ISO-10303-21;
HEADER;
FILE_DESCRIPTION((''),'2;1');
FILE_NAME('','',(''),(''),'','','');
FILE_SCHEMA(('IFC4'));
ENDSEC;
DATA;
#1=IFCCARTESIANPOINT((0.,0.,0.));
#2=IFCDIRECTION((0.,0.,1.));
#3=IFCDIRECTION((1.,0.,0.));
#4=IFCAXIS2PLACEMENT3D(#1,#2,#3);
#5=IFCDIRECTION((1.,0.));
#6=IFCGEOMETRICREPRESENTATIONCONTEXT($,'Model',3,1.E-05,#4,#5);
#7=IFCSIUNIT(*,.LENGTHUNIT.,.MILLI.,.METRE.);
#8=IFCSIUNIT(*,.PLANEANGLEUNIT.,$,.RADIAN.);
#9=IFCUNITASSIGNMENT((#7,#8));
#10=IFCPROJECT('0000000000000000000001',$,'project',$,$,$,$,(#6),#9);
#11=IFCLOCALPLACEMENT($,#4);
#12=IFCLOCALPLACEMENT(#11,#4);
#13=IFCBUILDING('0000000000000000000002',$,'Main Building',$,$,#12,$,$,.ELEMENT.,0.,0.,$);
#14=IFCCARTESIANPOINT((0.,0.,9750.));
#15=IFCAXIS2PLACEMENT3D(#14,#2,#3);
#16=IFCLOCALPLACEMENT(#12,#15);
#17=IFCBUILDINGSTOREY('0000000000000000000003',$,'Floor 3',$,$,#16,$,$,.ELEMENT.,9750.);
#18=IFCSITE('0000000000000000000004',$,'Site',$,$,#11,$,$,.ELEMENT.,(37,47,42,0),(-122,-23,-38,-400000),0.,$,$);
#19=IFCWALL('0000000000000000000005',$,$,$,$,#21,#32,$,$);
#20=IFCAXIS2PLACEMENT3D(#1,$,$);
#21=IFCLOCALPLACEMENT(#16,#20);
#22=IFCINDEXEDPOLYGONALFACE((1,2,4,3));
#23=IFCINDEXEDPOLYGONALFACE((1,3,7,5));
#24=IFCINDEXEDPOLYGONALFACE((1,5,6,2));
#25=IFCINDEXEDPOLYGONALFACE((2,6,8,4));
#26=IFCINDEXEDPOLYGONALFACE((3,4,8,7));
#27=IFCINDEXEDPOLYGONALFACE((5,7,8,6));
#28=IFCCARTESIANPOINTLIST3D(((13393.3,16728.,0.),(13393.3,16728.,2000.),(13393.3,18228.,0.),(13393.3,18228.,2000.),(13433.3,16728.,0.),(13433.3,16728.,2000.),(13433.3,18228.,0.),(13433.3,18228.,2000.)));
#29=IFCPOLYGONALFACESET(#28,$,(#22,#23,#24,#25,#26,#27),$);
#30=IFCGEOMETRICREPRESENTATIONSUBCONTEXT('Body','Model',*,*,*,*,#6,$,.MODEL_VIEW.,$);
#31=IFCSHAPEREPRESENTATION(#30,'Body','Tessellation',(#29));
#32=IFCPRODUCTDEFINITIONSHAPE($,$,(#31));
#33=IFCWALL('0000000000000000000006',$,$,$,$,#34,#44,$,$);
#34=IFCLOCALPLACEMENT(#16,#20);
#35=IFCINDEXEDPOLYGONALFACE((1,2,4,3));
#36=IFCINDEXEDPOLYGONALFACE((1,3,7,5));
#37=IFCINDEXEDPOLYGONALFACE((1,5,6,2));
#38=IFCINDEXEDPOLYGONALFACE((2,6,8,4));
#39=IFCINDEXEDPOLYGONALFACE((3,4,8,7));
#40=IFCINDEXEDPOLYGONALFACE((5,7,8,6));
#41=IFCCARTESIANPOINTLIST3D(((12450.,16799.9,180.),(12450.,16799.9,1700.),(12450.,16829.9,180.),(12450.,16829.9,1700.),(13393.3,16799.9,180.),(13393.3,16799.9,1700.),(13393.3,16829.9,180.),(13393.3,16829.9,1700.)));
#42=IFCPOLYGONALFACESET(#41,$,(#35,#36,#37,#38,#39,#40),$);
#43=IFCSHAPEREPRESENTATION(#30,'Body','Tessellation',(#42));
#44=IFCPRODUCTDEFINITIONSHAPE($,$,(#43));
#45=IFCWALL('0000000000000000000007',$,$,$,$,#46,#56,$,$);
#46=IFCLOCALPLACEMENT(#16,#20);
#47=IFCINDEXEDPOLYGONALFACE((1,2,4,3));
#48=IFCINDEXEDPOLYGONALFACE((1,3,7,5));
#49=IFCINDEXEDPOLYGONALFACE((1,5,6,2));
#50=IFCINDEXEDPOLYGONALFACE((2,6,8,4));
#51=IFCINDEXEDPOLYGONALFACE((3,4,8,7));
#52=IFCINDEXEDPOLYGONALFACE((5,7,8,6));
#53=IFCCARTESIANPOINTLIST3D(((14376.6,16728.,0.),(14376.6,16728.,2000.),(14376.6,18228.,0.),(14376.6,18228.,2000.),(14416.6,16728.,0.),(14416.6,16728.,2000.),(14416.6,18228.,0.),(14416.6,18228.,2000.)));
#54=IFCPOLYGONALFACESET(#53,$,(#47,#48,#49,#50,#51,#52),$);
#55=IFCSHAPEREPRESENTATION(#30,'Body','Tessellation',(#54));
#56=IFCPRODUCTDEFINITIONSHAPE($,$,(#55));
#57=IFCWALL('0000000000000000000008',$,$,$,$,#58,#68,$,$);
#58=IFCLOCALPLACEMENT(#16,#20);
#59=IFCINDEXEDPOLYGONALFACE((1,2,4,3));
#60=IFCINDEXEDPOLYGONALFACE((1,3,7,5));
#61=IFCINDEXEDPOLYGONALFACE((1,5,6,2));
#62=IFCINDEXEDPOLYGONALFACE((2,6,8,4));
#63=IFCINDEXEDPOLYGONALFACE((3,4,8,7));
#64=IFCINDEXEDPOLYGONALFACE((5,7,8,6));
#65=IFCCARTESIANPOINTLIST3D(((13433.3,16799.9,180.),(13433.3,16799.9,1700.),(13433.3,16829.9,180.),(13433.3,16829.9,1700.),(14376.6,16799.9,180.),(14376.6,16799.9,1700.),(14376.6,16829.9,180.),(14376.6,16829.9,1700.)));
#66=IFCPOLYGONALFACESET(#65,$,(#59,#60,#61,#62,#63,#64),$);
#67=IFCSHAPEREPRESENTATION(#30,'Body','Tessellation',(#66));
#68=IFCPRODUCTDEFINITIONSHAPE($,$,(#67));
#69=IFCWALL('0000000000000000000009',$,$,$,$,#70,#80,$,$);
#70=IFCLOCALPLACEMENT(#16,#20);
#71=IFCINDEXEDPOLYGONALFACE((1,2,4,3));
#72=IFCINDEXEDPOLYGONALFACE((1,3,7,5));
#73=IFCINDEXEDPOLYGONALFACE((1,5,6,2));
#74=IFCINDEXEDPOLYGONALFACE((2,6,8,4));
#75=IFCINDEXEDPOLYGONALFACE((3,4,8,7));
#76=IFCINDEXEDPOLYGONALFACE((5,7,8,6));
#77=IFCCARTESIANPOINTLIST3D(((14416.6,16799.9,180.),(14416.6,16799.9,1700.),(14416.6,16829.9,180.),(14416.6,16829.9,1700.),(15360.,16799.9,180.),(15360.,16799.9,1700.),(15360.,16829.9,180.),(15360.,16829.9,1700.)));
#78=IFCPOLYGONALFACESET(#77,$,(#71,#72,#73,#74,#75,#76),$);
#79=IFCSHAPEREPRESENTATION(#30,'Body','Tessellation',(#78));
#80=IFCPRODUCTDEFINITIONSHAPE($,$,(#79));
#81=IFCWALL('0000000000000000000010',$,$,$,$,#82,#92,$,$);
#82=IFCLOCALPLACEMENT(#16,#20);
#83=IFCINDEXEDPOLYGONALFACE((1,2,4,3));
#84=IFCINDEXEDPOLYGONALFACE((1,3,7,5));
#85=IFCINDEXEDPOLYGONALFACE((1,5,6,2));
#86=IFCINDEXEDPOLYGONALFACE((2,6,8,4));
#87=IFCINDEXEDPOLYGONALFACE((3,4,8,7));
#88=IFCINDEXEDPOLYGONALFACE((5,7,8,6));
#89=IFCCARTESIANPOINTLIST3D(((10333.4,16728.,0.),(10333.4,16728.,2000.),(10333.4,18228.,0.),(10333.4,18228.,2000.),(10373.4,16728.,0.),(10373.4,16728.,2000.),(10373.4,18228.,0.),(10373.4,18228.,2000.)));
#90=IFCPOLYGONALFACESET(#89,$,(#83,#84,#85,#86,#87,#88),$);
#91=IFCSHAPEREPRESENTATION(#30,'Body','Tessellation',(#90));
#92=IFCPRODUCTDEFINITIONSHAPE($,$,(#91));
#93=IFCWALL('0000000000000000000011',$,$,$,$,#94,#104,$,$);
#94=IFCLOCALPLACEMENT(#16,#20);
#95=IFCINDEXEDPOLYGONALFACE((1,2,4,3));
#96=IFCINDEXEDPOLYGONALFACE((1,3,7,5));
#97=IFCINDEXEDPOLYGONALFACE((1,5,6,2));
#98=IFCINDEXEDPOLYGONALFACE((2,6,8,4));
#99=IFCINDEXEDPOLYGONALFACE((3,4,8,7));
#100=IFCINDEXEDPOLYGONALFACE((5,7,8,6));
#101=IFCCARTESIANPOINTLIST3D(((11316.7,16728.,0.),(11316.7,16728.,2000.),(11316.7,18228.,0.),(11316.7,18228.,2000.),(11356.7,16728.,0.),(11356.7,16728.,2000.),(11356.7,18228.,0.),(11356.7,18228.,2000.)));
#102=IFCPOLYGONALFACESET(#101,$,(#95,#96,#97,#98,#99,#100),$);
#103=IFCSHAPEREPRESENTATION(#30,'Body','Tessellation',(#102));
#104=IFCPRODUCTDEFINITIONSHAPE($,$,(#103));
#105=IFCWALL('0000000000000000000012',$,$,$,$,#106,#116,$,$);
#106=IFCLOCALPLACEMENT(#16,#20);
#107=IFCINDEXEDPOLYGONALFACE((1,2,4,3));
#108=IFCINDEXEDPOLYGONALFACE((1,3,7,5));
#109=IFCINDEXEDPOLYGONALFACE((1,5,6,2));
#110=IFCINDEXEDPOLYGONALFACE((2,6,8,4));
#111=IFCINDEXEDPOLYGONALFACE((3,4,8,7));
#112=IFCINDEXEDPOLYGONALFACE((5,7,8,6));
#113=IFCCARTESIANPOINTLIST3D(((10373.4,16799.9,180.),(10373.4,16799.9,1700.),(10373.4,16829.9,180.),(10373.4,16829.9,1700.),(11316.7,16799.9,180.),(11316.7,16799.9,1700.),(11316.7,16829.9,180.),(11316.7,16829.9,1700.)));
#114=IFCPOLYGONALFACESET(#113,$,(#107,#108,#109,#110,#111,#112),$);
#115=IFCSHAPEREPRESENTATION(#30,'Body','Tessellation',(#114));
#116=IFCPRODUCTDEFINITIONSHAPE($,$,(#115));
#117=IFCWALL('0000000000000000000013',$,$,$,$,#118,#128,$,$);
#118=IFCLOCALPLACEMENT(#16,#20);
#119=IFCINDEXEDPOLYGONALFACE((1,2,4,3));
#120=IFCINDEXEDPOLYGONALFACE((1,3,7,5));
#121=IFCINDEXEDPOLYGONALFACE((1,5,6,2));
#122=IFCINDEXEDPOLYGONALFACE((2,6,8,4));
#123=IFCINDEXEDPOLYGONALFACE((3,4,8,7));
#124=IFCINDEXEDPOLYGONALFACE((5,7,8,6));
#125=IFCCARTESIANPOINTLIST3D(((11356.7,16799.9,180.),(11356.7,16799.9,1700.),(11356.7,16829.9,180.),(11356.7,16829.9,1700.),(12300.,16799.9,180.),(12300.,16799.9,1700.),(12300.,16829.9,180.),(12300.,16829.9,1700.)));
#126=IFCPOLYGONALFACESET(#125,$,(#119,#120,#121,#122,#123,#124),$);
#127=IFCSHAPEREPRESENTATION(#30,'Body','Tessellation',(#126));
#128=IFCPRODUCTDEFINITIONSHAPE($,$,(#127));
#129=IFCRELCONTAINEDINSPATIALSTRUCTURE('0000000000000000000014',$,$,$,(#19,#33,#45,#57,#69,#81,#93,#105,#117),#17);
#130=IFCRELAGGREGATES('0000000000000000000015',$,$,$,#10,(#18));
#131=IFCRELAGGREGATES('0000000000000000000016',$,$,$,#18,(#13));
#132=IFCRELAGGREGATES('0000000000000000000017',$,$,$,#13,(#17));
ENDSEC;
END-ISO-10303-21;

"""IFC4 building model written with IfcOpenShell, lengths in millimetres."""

from ifc_helpers import new_model, si_unit, direction, frame, frame_2d, origin_with_axes, origin_2d_with_axis, place, context, subcontext, project, spatial, rectangle, extrude, element, save


model = new_model("IFC4")

# Units and contexts
model_context = context("Model", 3, precision=1e-05, world=origin_with_axes(), true_north=direction((1.0, 0.0)))
body_context = subcontext(model_context, "Body", "Model", "MODEL_VIEW")
ifc_project = project(units=[si_unit("LENGTHUNIT", "METRE", prefix="MILLI"), si_unit("PLANEANGLEUNIT", "RADIAN")], contexts=[model_context])

# Site, building, storey
site_placement = place(None, origin_with_axes())
site = spatial("IfcSite", under=ifc_project, at=site_placement, Name="Site", CompositionType="ELEMENT", RefLatitude=(37, 47, 42, 0), RefLongitude=(-122, -23, -38, -400000), RefElevation=0.0)
building_placement = place(site_placement, origin_with_axes())
building = spatial("IfcBuilding", under=site, at=building_placement, Name="Main Building", CompositionType="ELEMENT", ElevationOfRefHeight=0.0, ElevationOfTerrain=0.0)
storey_placement = place(building_placement, frame((0.0, 0.0, 9750.0), z_axis=(0.0, 0.0, 1.0), x_axis=(1.0, 0.0, 0.0)))
storey = spatial("IfcBuildingStorey", under=building, at=storey_placement, Name="Floor 3", CompositionType="ELEMENT", Elevation=9750.0)

# Walls
wall_1_placement = place(storey_placement, origin_with_axes())
element("IfcWall", 1, at=wall_1_placement, inside=storey, context=body_context, shape_type="SweptSolid", body=[
    extrude(rectangle(XDim=1500.0, YDim=40.0, at=frame_2d((0.0, 0.0), x_axis=(0.0, 1.0))), frame((13413.3, 17478.0, 0.0), z_axis=(0.0, 0.0, 1.0), x_axis=(1.0, 0.0, 0.0)), (0.0, 0.0, 1.0), 2000.0),
])
wall_2_placement = place(storey_placement, origin_with_axes())
element("IfcWall", 2, at=wall_2_placement, inside=storey, context=body_context, shape_type="SweptSolid", body=[
    extrude(rectangle(XDim=943.3, YDim=30.0, at=origin_2d_with_axis()), frame((12921.7, 16814.9, 180.0), z_axis=(0.0, 0.0, 1.0), x_axis=(1.0, 0.0, 0.0)), (0.0, 0.0, 1.0), 1520.0),
])
wall_3_placement = place(storey_placement, origin_with_axes())
element("IfcWall", 3, at=wall_3_placement, inside=storey, context=body_context, shape_type="SweptSolid", body=[
    extrude(rectangle(XDim=1500.0, YDim=40.0, at=frame_2d((0.0, 0.0), x_axis=(0.0, 1.0))), frame((14396.6, 17478.0, 0.0), z_axis=(0.0, 0.0, 1.0), x_axis=(1.0, 0.0, 0.0)), (0.0, 0.0, 1.0), 2000.0),
])
wall_4_placement = place(storey_placement, origin_with_axes())
element("IfcWall", 4, at=wall_4_placement, inside=storey, context=body_context, shape_type="SweptSolid", body=[
    extrude(rectangle(XDim=943.3, YDim=30.0, at=origin_2d_with_axis()), frame((13905.0, 16814.9, 180.0), z_axis=(0.0, 0.0, 1.0), x_axis=(1.0, 0.0, 0.0)), (0.0, 0.0, 1.0), 1520.0),
])
wall_5_placement = place(storey_placement, origin_with_axes())
element("IfcWall", 5, at=wall_5_placement, inside=storey, context=body_context, shape_type="SweptSolid", body=[
    extrude(rectangle(XDim=943.3, YDim=30.0, at=origin_2d_with_axis()), frame((14888.3, 16814.9, 180.0), z_axis=(0.0, 0.0, 1.0), x_axis=(1.0, 0.0, 0.0)), (0.0, 0.0, 1.0), 1520.0),
])
wall_6_placement = place(storey_placement, origin_with_axes())
element("IfcWall", 6, at=wall_6_placement, inside=storey, context=body_context, shape_type="SweptSolid", body=[
    extrude(rectangle(XDim=1500.0, YDim=40.0, at=frame_2d((0.0, 0.0), x_axis=(0.0, 1.0))), frame((10353.4, 17478.0, 0.0), z_axis=(0.0, 0.0, 1.0), x_axis=(1.0, 0.0, 0.0)), (0.0, 0.0, 1.0), 2000.0),
])
wall_7_placement = place(storey_placement, origin_with_axes())
element("IfcWall", 7, at=wall_7_placement, inside=storey, context=body_context, shape_type="SweptSolid", body=[
    extrude(rectangle(XDim=1500.0, YDim=40.0, at=frame_2d((0.0, 0.0), x_axis=(0.0, 1.0))), frame((11336.7, 17478.0, 0.0), z_axis=(0.0, 0.0, 1.0), x_axis=(1.0, 0.0, 0.0)), (0.0, 0.0, 1.0), 2000.0),
])
wall_8_placement = place(storey_placement, origin_with_axes())
element("IfcWall", 8, at=wall_8_placement, inside=storey, context=body_context, shape_type="SweptSolid", body=[
    extrude(rectangle(XDim=943.3, YDim=30.0, at=origin_2d_with_axis()), frame((10845.0, 16814.9, 180.0), z_axis=(0.0, 0.0, 1.0), x_axis=(1.0, 0.0, 0.0)), (0.0, 0.0, 1.0), 1520.0),
])
wall_9_placement = place(storey_placement, origin_with_axes())
element("IfcWall", 9, at=wall_9_placement, inside=storey, context=body_context, shape_type="SweptSolid", body=[
    extrude(rectangle(XDim=943.3, YDim=30.0, at=origin_2d_with_axis()), frame((11828.3, 16814.9, 180.0), z_axis=(0.0, 0.0, 1.0), x_axis=(1.0, 0.0, 0.0)), (0.0, 0.0, 1.0), 1520.0),
])

save(model, "model.ifc")
